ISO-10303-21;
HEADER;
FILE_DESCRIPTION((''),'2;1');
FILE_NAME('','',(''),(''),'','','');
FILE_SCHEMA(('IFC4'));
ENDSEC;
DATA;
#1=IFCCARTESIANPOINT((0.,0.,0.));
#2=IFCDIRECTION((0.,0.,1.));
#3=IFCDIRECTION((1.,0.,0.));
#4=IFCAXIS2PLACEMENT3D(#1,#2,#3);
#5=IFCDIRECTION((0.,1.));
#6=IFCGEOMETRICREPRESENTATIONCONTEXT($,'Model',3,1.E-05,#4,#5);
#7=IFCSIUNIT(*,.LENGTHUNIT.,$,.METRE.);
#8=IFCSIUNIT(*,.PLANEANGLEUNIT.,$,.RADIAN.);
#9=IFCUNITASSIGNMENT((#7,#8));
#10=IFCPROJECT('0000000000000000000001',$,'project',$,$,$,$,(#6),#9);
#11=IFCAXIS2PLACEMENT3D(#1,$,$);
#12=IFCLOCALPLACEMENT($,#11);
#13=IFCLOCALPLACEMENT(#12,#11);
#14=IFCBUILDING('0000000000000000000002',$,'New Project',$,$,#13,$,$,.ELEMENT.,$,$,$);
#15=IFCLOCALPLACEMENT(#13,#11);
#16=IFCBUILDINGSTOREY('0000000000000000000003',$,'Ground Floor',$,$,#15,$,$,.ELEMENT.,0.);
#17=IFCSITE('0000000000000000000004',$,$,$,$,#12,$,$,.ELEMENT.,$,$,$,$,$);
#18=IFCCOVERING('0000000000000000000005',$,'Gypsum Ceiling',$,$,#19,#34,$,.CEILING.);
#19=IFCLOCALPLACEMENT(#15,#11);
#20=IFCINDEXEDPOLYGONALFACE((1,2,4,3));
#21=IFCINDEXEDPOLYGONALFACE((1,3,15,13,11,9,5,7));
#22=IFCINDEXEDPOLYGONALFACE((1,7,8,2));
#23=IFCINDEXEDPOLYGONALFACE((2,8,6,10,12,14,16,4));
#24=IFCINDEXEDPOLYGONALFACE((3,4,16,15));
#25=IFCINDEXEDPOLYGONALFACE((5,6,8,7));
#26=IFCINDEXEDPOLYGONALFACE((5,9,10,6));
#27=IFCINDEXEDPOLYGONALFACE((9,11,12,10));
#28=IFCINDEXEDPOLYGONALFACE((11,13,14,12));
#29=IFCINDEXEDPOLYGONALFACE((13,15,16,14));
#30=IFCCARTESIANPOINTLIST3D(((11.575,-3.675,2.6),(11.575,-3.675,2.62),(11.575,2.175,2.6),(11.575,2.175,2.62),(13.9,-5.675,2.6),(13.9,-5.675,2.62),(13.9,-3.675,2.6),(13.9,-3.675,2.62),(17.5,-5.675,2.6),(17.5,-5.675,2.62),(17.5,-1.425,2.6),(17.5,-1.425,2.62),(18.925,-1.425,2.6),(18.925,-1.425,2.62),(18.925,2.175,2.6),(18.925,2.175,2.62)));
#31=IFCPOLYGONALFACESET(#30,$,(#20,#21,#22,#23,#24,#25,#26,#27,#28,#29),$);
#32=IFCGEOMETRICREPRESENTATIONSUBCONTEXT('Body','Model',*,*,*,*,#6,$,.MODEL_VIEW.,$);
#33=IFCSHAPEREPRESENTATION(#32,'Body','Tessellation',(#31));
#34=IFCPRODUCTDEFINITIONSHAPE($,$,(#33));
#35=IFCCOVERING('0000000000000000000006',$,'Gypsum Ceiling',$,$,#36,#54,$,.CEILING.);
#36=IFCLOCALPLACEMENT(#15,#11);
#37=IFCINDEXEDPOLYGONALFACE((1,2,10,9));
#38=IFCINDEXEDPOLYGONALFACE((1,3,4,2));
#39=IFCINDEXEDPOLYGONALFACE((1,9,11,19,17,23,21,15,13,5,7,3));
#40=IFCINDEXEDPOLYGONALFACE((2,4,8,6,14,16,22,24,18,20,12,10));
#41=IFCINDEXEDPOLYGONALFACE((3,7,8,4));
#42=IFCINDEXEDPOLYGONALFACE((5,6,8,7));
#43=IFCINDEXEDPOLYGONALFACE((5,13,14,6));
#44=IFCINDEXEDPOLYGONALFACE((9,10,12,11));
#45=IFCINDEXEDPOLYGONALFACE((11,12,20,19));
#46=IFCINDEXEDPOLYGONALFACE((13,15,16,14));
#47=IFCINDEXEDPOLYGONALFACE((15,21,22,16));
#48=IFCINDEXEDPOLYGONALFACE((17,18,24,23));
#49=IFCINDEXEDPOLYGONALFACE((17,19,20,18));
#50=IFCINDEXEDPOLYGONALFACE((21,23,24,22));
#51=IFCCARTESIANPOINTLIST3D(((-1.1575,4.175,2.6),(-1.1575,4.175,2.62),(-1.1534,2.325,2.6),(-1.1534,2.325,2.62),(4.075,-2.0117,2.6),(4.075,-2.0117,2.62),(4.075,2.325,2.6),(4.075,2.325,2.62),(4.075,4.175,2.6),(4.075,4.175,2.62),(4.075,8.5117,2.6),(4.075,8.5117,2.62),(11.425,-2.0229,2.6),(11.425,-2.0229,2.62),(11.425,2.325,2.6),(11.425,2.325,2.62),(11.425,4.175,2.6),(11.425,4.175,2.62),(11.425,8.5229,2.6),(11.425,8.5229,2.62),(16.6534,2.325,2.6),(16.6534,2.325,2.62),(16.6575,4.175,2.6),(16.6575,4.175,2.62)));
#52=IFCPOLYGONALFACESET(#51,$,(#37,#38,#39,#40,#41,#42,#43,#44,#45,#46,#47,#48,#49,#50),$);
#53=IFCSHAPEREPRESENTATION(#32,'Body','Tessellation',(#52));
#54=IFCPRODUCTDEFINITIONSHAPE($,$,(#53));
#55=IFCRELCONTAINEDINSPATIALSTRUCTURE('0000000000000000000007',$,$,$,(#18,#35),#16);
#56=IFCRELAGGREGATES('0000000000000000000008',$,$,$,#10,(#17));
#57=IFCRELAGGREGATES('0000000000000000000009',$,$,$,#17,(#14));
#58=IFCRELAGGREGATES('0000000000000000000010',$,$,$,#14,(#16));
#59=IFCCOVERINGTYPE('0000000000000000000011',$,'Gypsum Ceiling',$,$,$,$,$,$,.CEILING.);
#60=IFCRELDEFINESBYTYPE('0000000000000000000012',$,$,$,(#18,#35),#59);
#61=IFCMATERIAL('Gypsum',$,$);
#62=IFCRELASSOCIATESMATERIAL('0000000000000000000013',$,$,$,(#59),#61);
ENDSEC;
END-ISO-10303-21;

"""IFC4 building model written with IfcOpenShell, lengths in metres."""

from ifc_helpers import new_model, si_unit, direction, frame, origin, origin_with_axes, place, context, subcontext, project, spatial, polyline, outline, extrude, material, type_object, element, save


model = new_model("IFC4")

# Units and contexts
model_context = context("Model", 3, precision=1e-05, world=origin_with_axes(), true_north=direction((0.0, 1.0)))
body_context = subcontext(model_context, "Body", "Model", "MODEL_VIEW")
ifc_project = project(units=[si_unit("LENGTHUNIT", "METRE"), si_unit("PLANEANGLEUNIT", "RADIAN")], contexts=[model_context])

# Site, building, storey
site_placement = place(None, origin())
site = spatial("IfcSite", under=ifc_project, at=site_placement, CompositionType="ELEMENT")
building_placement = place(site_placement, origin())
building = spatial("IfcBuilding", under=site, at=building_placement, Name="New Project", CompositionType="ELEMENT")
storey_placement = place(building_placement, origin())
storey = spatial("IfcBuildingStorey", under=building, at=storey_placement, Name="Ground Floor", CompositionType="ELEMENT", Elevation=0.0)

# Coverings
ifc_material_1 = material(Name="Gypsum")
covering_type = type_object("IfcCoveringType", Name="Gypsum Ceiling", PredefinedType="CEILING", material=ifc_material_1)
covering_1_placement = place(storey_placement, frame((0.0, 0.0, 2.6)))
element("IfcCovering", 1, at=covering_1_placement, inside=storey, type_object=covering_type, Name="Gypsum Ceiling", PredefinedType="CEILING", context=body_context, shape_type="SweptSolid", body=[
    extrude(outline(polyline([(17.5, -1.425), (18.925, -1.425), (18.925, 2.175), (11.575, 2.175), (11.575, -3.675), (13.9, -3.675), (13.9, -5.675), (17.5, -5.675), (17.5, -1.425)])), origin(), (0.0, 0.0, 1.0), 0.02),
])
covering_2_placement = place(storey_placement, frame((0.0, 0.0, 2.6)))
element("IfcCovering", 2, at=covering_2_placement, inside=storey, type_object=covering_type, Name="Gypsum Ceiling", PredefinedType="CEILING", context=body_context, shape_type="SweptSolid", body=[
    extrude(outline(polyline([(4.075, 4.175), (-1.1575, 4.175), (-1.1534, 2.325), (4.075, 2.325), (4.075, -2.0117), (11.425, -2.0229), (11.425, 2.325), (16.6534, 2.325), (16.6575, 4.175), (11.425, 4.175), (11.425, 8.5229), (4.075, 8.5117), (4.075, 4.175)])), origin(), (0.0, 0.0, 1.0), 0.02),
])

save(model, "model.ifc")
